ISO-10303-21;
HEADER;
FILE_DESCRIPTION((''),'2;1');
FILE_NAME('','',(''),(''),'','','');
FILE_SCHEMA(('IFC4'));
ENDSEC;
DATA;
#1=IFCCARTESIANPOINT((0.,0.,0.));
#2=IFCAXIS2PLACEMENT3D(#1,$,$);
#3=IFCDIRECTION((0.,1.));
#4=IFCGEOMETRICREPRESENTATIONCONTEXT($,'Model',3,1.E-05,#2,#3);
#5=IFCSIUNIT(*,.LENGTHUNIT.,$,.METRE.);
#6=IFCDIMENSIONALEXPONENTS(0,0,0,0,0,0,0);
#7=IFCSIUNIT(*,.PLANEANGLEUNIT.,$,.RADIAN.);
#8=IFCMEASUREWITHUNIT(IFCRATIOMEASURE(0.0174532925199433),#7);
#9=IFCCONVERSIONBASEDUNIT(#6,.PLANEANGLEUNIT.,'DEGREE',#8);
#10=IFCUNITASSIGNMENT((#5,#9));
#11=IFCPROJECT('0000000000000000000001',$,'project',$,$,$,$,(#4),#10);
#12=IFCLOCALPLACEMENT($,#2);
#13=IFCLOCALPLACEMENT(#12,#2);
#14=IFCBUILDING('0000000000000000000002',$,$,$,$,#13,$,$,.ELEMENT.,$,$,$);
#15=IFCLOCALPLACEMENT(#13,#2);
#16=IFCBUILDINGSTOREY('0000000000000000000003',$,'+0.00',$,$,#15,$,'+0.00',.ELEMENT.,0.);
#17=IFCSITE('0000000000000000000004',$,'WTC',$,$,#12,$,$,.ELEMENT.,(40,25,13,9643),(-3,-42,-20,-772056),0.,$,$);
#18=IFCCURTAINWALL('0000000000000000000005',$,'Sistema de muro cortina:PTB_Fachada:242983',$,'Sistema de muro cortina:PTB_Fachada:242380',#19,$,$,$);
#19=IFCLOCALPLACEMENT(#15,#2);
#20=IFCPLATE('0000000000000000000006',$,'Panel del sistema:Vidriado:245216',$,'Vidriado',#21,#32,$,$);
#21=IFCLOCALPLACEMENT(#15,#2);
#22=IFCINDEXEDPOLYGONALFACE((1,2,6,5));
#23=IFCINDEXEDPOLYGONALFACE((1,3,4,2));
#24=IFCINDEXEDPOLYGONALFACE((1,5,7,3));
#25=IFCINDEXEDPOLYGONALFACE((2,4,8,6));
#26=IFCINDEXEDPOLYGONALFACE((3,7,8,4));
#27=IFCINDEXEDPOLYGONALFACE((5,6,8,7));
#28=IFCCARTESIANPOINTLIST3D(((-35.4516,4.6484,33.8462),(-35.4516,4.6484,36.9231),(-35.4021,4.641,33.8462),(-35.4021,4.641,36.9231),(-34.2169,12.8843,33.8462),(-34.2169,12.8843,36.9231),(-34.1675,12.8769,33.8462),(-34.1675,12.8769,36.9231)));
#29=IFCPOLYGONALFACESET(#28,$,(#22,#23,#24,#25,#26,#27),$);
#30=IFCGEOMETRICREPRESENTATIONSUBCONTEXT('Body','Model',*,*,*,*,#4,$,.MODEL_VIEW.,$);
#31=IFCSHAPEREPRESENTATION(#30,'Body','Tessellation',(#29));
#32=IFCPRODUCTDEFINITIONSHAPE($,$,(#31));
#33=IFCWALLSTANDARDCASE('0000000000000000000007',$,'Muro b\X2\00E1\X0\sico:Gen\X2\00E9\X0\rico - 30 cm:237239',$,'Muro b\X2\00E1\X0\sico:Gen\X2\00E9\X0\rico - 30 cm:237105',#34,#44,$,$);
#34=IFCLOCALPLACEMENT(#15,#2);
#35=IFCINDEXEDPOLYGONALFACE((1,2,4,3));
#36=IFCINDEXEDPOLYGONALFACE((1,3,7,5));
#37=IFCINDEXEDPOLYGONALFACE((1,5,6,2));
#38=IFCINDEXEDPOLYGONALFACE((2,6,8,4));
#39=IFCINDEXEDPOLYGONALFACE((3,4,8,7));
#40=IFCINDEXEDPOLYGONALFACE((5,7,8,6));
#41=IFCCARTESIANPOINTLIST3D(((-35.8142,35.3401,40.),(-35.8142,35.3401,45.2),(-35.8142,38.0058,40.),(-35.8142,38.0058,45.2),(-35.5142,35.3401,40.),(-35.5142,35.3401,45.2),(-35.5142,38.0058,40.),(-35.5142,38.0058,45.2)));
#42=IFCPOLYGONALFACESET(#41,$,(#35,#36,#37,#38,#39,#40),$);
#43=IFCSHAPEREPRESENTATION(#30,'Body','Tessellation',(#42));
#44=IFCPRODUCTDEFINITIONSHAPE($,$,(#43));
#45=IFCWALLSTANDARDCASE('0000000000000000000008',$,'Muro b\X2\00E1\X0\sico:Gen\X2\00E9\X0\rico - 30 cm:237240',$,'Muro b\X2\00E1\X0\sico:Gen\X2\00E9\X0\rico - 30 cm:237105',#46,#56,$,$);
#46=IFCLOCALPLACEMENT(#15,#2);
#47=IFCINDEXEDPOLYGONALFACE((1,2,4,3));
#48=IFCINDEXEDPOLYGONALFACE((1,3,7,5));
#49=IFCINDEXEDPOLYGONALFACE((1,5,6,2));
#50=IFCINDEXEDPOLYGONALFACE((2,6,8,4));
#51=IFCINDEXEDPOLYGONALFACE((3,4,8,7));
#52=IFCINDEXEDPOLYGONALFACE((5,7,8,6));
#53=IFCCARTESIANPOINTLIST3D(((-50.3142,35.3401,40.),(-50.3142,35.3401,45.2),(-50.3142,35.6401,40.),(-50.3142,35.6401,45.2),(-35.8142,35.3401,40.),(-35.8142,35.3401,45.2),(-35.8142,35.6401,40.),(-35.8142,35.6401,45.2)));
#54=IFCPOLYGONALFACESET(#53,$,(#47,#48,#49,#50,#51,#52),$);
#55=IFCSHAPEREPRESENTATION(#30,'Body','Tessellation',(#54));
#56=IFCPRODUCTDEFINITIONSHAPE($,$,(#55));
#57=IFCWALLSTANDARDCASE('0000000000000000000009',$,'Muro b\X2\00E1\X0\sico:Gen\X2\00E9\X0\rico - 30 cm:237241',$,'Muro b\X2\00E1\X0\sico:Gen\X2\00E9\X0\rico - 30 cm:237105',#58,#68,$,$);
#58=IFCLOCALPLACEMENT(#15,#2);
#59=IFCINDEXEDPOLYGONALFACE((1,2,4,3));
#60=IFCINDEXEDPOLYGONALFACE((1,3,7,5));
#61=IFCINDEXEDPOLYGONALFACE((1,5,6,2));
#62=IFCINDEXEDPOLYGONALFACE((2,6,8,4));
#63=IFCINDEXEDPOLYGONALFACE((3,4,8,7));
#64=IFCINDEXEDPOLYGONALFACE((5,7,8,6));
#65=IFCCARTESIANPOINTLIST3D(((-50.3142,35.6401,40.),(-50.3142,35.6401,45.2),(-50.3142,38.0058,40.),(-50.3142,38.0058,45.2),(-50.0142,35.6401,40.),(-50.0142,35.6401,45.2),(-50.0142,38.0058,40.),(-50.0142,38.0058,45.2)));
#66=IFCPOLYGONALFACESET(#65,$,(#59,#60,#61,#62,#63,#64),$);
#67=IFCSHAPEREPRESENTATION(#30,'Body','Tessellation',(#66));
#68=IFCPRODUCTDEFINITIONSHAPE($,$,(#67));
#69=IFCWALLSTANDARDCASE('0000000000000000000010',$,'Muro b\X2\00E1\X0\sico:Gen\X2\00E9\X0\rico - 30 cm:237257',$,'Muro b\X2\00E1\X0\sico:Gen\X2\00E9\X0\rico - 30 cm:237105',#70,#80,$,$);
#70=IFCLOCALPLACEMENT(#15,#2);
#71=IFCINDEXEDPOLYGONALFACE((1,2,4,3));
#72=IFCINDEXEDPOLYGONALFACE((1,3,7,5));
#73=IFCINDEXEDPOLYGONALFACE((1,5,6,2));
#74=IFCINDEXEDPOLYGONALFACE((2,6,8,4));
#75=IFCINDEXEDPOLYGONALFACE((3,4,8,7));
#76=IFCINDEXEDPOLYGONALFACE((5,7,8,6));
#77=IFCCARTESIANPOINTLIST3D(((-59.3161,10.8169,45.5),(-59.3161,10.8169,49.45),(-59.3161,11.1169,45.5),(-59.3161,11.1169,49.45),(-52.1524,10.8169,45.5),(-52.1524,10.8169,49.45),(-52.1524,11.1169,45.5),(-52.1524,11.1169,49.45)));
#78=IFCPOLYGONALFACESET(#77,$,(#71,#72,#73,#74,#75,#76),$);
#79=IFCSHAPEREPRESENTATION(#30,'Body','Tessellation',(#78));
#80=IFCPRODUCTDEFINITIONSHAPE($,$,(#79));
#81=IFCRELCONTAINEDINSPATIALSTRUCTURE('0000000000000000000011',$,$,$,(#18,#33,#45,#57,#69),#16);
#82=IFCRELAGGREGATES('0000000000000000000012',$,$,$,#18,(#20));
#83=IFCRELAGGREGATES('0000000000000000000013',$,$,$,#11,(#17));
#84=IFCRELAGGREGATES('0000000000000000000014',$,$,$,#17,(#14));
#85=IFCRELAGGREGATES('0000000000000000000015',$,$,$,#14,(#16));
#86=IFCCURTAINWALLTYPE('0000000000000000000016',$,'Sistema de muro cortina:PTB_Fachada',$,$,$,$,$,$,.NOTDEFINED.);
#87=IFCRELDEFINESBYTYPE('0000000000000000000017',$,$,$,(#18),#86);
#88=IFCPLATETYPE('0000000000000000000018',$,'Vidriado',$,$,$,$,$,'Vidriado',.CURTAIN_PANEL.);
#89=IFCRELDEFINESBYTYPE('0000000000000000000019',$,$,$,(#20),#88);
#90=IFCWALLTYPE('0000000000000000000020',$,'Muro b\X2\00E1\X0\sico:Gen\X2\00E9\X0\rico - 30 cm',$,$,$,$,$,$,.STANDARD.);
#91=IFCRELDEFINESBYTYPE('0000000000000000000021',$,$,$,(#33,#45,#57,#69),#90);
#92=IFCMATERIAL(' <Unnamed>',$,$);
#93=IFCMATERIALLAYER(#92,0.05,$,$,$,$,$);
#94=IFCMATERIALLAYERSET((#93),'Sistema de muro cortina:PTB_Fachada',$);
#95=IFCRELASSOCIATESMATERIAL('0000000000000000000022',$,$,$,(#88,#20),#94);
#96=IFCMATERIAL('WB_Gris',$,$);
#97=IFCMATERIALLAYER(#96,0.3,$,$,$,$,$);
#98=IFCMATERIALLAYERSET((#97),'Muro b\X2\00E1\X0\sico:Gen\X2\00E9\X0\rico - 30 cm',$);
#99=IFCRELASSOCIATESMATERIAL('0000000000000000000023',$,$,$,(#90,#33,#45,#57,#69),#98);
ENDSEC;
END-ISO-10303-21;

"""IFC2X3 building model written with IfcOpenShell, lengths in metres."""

from ifc_helpers import new_model, entity, si_unit, converted_unit, direction, frame, frame_2d, origin, place, context, subcontext, project, spatial, polyline, rectangle, extrude, clip, bounded_halfspace, source, transform, mapped, material, layer, layer_set, layer_usage, type_object, type_shapes, element, aggregate, save


model = new_model("IFC2X3")

# Units and contexts
model_context = context("Model", 3, precision=1e-05, world=origin(), true_north=direction((0.0, 1.0)))
body_context = subcontext(model_context, "Body", "Model", "MODEL_VIEW")
ifc_project = project(units=[si_unit("LENGTHUNIT", "METRE"), converted_unit("PLANEANGLEUNIT", "DEGREE", entity("IfcRatioMeasure", 0.0174532925199433), si_unit("PLANEANGLEUNIT", "RADIAN"), dimensions=[0, 0, 0, 0, 0, 0, 0])], contexts=[model_context])

# Site, building, storey
site_placement = place(None, origin())
site = spatial("IfcSite", under=ifc_project, at=site_placement, Name="WTC", CompositionType="ELEMENT", RefLatitude=(40, 25, 13, 9643), RefLongitude=(-3, -42, -20, -772056), RefElevation=0.0)
building_placement = place(site_placement, origin())
building = spatial("IfcBuilding", under=site, at=building_placement, CompositionType="ELEMENT")
storey_placement = place(building_placement, origin())
storey = spatial("IfcBuildingStorey", under=building, at=storey_placement, Name="+0.00", LongName="+0.00", CompositionType="ELEMENT", Elevation=0.0)

# Curtain wall, plate
curtain_wall_type = type_object("IfcCurtainWallType", Name="Sistema de muro cortina:PTB_Fachada", PredefinedType="NOTDEFINED")
ifc_material_1 = material(Name=" <Unnamed>")
ifc_layer_1 = layer(ifc_material_1, 0.05)
ifc_layer_set_1 = layer_set([ifc_layer_1], Name="Sistema de muro cortina:PTB_Fachada")
curtain_wall_1_placement = place(storey_placement, origin())
curtain_wall_1 = element("IfcCurtainWall", 1, at=curtain_wall_1_placement, inside=storey, type_object=curtain_wall_type, Name="Sistema de muro cortina:PTB_Fachada:242983", ObjectType="Sistema de muro cortina:PTB_Fachada:242380")
plate_type_1 = type_object("IfcPlateType", Name="Vidriado", ElementType="Vidriado", PredefinedType="CURTAIN_PANEL", material=ifc_layer_set_1)
shared_shape_1 = source(origin(), body_context, "Body", "SweptSolid", [
    extrude(rectangle(XDim=0.05, YDim=8.3279, at=frame_2d((0.0, 0.0), x_axis=(1.0, 0.0))), frame((0.0, 0.0, 0.0), z_axis=(0.0, 0.0, 1.0), x_axis=(0.0, 1.0, 0.0)), (0.0, 0.0, 1.0), 3.0769),
])
type_shapes(plate_type_1, [shared_shape_1])
ifc_layer_usage_1 = layer_usage(ifc_layer_set_1, "AXIS3", "POSITIVE", 0.0)
plate_1_placement = place(curtain_wall_1_placement, frame((-34.8095, 8.7626, 36.9231), z_axis=(0.0, 0.0, -1.0), x_axis=(-0.148255, -0.988949, 0.0)))
plate_1 = element("IfcPlate", 2, at=plate_1_placement, type_object=plate_type_1, material=ifc_layer_usage_1, Name="Panel del sistema:Vidriado:245216", ObjectType="Vidriado", context=body_context, shape_type="MappedRepresentation", body=[
    mapped(shared_shape_1, transform((0.0, 0.0, 0.0), scale=1.0)),
])
aggregate(curtain_wall_1, [plate_1])

# Walls
ifc_material_2 = material(Name="WB_Gris")
ifc_layer_2 = layer(ifc_material_2, 0.3)
ifc_layer_set_2 = layer_set([ifc_layer_2], Name="Muro básico:Genérico - 30 cm")
wall_type = type_object("IfcWallType", Name="Muro básico:Genérico - 30 cm", PredefinedType="STANDARD", material=ifc_layer_set_2)
ifc_layer_usage_2 = layer_usage(ifc_layer_set_2, "AXIS2", "POSITIVE", -0.15)
wall_1_placement = place(storey_placement, frame((-35.6642, 35.3401, 40.0), z_axis=(0.0, 0.0, 1.0), x_axis=(0.0, 1.0, 0.0)))
element("IfcWallStandardCase", 3, at=wall_1_placement, inside=storey, type_object=wall_type, material=ifc_layer_usage_2, Name="Muro básico:Genérico - 30 cm:237239", ObjectType="Muro básico:Genérico - 30 cm:237105", context=body_context, shape_type="Clipping", body=[
    clip(extrude(rectangle(XDim=2.6657, YDim=0.3, at=frame_2d((1.3329, 0.0), x_axis=(-1.0, 0.0))), origin(), (0.0, 0.0, 1.0), 5.2), bounded_halfspace(frame((0.0, -0.15, 5.2), z_axis=(0.0, 0.0, 1.0), x_axis=(0.0, -1.0, 0.0)), False, frame((0.0, -0.15, 5.2), z_axis=(0.0, 0.0, 1.0), x_axis=(0.0, -1.0, 0.0)), polyline([(0.0, 0.0), (0.0, 2.6657), (-0.3, 2.6657), (-0.3, 0.0), (0.0, 0.0)]))),
])
ifc_layer_usage_3 = layer_usage(ifc_layer_set_2, "AXIS2", "POSITIVE", -0.15)
wall_2_placement = place(storey_placement, frame((-50.3142, 35.4901, 40.0)))
element("IfcWallStandardCase", 4, at=wall_2_placement, inside=storey, type_object=wall_type, material=ifc_layer_usage_3, Name="Muro básico:Genérico - 30 cm:237240", ObjectType="Muro básico:Genérico - 30 cm:237105", context=body_context, shape_type="Clipping", body=[
    clip(extrude(rectangle(XDim=14.5, YDim=0.3, at=frame_2d((7.25, 0.0), x_axis=(-1.0, 0.0))), origin(), (0.0, 0.0, 1.0), 5.2), bounded_halfspace(frame((0.0, -0.15, 5.2)), False, frame((0.0, -0.15, 5.2)), polyline([(0.0, 0.0), (14.5, 0.0), (14.5, 0.3), (0.0, 0.3), (0.0, 0.0)]))),
])
ifc_layer_usage_4 = layer_usage(ifc_layer_set_2, "AXIS2", "POSITIVE", -0.15)
wall_3_placement = place(storey_placement, frame((-50.1642, 38.0058, 40.0), z_axis=(0.0, 0.0, 1.0), x_axis=(0.0, -1.0, 0.0)))
element("IfcWallStandardCase", 5, at=wall_3_placement, inside=storey, type_object=wall_type, material=ifc_layer_usage_4, Name="Muro básico:Genérico - 30 cm:237241", ObjectType="Muro básico:Genérico - 30 cm:237105", context=body_context, shape_type="Clipping", body=[
    clip(extrude(rectangle(XDim=2.3657, YDim=0.3, at=frame_2d((1.1829, 0.0), x_axis=(-1.0, 0.0))), origin(), (0.0, 0.0, 1.0), 5.2), bounded_halfspace(frame((0.0, -0.15, 5.2), z_axis=(0.0, 0.0, 1.0), x_axis=(0.0, 1.0, 0.0)), False, frame((0.0, -0.15, 5.2), z_axis=(0.0, 0.0, 1.0), x_axis=(0.0, 1.0, 0.0)), polyline([(0.0, 0.0), (0.0, -2.3657), (0.3, -2.3657), (0.3, 0.0), (0.0, 0.0)]))),
])
ifc_layer_usage_5 = layer_usage(ifc_layer_set_2, "AXIS2", "NEGATIVE", 0.15)
wall_4_placement = place(storey_placement, frame((-52.1524, 10.9669, 45.5), z_axis=(0.0, 0.0, 1.0), x_axis=(-1.0, 0.0, 0.0)))
element("IfcWallStandardCase", 6, at=wall_4_placement, inside=storey, type_object=wall_type, material=ifc_layer_usage_5, Name="Muro básico:Genérico - 30 cm:237257", ObjectType="Muro básico:Genérico - 30 cm:237105", context=body_context, shape_type="Clipping", body=[
    clip(extrude(rectangle(XDim=7.1637, YDim=0.3, at=frame_2d((3.5819, 0.0), x_axis=(-1.0, 0.0))), origin(), (0.0, 0.0, 1.0), 3.95), bounded_halfspace(frame((0.0, -0.15, 3.95)), False, frame((0.0, -0.15, 3.95)), polyline([(0.0, 0.0), (7.1637, 0.0), (7.1637, 0.3), (0.0, 0.3), (0.0, 0.0)]))),
])

save(model, "model.ifc")
